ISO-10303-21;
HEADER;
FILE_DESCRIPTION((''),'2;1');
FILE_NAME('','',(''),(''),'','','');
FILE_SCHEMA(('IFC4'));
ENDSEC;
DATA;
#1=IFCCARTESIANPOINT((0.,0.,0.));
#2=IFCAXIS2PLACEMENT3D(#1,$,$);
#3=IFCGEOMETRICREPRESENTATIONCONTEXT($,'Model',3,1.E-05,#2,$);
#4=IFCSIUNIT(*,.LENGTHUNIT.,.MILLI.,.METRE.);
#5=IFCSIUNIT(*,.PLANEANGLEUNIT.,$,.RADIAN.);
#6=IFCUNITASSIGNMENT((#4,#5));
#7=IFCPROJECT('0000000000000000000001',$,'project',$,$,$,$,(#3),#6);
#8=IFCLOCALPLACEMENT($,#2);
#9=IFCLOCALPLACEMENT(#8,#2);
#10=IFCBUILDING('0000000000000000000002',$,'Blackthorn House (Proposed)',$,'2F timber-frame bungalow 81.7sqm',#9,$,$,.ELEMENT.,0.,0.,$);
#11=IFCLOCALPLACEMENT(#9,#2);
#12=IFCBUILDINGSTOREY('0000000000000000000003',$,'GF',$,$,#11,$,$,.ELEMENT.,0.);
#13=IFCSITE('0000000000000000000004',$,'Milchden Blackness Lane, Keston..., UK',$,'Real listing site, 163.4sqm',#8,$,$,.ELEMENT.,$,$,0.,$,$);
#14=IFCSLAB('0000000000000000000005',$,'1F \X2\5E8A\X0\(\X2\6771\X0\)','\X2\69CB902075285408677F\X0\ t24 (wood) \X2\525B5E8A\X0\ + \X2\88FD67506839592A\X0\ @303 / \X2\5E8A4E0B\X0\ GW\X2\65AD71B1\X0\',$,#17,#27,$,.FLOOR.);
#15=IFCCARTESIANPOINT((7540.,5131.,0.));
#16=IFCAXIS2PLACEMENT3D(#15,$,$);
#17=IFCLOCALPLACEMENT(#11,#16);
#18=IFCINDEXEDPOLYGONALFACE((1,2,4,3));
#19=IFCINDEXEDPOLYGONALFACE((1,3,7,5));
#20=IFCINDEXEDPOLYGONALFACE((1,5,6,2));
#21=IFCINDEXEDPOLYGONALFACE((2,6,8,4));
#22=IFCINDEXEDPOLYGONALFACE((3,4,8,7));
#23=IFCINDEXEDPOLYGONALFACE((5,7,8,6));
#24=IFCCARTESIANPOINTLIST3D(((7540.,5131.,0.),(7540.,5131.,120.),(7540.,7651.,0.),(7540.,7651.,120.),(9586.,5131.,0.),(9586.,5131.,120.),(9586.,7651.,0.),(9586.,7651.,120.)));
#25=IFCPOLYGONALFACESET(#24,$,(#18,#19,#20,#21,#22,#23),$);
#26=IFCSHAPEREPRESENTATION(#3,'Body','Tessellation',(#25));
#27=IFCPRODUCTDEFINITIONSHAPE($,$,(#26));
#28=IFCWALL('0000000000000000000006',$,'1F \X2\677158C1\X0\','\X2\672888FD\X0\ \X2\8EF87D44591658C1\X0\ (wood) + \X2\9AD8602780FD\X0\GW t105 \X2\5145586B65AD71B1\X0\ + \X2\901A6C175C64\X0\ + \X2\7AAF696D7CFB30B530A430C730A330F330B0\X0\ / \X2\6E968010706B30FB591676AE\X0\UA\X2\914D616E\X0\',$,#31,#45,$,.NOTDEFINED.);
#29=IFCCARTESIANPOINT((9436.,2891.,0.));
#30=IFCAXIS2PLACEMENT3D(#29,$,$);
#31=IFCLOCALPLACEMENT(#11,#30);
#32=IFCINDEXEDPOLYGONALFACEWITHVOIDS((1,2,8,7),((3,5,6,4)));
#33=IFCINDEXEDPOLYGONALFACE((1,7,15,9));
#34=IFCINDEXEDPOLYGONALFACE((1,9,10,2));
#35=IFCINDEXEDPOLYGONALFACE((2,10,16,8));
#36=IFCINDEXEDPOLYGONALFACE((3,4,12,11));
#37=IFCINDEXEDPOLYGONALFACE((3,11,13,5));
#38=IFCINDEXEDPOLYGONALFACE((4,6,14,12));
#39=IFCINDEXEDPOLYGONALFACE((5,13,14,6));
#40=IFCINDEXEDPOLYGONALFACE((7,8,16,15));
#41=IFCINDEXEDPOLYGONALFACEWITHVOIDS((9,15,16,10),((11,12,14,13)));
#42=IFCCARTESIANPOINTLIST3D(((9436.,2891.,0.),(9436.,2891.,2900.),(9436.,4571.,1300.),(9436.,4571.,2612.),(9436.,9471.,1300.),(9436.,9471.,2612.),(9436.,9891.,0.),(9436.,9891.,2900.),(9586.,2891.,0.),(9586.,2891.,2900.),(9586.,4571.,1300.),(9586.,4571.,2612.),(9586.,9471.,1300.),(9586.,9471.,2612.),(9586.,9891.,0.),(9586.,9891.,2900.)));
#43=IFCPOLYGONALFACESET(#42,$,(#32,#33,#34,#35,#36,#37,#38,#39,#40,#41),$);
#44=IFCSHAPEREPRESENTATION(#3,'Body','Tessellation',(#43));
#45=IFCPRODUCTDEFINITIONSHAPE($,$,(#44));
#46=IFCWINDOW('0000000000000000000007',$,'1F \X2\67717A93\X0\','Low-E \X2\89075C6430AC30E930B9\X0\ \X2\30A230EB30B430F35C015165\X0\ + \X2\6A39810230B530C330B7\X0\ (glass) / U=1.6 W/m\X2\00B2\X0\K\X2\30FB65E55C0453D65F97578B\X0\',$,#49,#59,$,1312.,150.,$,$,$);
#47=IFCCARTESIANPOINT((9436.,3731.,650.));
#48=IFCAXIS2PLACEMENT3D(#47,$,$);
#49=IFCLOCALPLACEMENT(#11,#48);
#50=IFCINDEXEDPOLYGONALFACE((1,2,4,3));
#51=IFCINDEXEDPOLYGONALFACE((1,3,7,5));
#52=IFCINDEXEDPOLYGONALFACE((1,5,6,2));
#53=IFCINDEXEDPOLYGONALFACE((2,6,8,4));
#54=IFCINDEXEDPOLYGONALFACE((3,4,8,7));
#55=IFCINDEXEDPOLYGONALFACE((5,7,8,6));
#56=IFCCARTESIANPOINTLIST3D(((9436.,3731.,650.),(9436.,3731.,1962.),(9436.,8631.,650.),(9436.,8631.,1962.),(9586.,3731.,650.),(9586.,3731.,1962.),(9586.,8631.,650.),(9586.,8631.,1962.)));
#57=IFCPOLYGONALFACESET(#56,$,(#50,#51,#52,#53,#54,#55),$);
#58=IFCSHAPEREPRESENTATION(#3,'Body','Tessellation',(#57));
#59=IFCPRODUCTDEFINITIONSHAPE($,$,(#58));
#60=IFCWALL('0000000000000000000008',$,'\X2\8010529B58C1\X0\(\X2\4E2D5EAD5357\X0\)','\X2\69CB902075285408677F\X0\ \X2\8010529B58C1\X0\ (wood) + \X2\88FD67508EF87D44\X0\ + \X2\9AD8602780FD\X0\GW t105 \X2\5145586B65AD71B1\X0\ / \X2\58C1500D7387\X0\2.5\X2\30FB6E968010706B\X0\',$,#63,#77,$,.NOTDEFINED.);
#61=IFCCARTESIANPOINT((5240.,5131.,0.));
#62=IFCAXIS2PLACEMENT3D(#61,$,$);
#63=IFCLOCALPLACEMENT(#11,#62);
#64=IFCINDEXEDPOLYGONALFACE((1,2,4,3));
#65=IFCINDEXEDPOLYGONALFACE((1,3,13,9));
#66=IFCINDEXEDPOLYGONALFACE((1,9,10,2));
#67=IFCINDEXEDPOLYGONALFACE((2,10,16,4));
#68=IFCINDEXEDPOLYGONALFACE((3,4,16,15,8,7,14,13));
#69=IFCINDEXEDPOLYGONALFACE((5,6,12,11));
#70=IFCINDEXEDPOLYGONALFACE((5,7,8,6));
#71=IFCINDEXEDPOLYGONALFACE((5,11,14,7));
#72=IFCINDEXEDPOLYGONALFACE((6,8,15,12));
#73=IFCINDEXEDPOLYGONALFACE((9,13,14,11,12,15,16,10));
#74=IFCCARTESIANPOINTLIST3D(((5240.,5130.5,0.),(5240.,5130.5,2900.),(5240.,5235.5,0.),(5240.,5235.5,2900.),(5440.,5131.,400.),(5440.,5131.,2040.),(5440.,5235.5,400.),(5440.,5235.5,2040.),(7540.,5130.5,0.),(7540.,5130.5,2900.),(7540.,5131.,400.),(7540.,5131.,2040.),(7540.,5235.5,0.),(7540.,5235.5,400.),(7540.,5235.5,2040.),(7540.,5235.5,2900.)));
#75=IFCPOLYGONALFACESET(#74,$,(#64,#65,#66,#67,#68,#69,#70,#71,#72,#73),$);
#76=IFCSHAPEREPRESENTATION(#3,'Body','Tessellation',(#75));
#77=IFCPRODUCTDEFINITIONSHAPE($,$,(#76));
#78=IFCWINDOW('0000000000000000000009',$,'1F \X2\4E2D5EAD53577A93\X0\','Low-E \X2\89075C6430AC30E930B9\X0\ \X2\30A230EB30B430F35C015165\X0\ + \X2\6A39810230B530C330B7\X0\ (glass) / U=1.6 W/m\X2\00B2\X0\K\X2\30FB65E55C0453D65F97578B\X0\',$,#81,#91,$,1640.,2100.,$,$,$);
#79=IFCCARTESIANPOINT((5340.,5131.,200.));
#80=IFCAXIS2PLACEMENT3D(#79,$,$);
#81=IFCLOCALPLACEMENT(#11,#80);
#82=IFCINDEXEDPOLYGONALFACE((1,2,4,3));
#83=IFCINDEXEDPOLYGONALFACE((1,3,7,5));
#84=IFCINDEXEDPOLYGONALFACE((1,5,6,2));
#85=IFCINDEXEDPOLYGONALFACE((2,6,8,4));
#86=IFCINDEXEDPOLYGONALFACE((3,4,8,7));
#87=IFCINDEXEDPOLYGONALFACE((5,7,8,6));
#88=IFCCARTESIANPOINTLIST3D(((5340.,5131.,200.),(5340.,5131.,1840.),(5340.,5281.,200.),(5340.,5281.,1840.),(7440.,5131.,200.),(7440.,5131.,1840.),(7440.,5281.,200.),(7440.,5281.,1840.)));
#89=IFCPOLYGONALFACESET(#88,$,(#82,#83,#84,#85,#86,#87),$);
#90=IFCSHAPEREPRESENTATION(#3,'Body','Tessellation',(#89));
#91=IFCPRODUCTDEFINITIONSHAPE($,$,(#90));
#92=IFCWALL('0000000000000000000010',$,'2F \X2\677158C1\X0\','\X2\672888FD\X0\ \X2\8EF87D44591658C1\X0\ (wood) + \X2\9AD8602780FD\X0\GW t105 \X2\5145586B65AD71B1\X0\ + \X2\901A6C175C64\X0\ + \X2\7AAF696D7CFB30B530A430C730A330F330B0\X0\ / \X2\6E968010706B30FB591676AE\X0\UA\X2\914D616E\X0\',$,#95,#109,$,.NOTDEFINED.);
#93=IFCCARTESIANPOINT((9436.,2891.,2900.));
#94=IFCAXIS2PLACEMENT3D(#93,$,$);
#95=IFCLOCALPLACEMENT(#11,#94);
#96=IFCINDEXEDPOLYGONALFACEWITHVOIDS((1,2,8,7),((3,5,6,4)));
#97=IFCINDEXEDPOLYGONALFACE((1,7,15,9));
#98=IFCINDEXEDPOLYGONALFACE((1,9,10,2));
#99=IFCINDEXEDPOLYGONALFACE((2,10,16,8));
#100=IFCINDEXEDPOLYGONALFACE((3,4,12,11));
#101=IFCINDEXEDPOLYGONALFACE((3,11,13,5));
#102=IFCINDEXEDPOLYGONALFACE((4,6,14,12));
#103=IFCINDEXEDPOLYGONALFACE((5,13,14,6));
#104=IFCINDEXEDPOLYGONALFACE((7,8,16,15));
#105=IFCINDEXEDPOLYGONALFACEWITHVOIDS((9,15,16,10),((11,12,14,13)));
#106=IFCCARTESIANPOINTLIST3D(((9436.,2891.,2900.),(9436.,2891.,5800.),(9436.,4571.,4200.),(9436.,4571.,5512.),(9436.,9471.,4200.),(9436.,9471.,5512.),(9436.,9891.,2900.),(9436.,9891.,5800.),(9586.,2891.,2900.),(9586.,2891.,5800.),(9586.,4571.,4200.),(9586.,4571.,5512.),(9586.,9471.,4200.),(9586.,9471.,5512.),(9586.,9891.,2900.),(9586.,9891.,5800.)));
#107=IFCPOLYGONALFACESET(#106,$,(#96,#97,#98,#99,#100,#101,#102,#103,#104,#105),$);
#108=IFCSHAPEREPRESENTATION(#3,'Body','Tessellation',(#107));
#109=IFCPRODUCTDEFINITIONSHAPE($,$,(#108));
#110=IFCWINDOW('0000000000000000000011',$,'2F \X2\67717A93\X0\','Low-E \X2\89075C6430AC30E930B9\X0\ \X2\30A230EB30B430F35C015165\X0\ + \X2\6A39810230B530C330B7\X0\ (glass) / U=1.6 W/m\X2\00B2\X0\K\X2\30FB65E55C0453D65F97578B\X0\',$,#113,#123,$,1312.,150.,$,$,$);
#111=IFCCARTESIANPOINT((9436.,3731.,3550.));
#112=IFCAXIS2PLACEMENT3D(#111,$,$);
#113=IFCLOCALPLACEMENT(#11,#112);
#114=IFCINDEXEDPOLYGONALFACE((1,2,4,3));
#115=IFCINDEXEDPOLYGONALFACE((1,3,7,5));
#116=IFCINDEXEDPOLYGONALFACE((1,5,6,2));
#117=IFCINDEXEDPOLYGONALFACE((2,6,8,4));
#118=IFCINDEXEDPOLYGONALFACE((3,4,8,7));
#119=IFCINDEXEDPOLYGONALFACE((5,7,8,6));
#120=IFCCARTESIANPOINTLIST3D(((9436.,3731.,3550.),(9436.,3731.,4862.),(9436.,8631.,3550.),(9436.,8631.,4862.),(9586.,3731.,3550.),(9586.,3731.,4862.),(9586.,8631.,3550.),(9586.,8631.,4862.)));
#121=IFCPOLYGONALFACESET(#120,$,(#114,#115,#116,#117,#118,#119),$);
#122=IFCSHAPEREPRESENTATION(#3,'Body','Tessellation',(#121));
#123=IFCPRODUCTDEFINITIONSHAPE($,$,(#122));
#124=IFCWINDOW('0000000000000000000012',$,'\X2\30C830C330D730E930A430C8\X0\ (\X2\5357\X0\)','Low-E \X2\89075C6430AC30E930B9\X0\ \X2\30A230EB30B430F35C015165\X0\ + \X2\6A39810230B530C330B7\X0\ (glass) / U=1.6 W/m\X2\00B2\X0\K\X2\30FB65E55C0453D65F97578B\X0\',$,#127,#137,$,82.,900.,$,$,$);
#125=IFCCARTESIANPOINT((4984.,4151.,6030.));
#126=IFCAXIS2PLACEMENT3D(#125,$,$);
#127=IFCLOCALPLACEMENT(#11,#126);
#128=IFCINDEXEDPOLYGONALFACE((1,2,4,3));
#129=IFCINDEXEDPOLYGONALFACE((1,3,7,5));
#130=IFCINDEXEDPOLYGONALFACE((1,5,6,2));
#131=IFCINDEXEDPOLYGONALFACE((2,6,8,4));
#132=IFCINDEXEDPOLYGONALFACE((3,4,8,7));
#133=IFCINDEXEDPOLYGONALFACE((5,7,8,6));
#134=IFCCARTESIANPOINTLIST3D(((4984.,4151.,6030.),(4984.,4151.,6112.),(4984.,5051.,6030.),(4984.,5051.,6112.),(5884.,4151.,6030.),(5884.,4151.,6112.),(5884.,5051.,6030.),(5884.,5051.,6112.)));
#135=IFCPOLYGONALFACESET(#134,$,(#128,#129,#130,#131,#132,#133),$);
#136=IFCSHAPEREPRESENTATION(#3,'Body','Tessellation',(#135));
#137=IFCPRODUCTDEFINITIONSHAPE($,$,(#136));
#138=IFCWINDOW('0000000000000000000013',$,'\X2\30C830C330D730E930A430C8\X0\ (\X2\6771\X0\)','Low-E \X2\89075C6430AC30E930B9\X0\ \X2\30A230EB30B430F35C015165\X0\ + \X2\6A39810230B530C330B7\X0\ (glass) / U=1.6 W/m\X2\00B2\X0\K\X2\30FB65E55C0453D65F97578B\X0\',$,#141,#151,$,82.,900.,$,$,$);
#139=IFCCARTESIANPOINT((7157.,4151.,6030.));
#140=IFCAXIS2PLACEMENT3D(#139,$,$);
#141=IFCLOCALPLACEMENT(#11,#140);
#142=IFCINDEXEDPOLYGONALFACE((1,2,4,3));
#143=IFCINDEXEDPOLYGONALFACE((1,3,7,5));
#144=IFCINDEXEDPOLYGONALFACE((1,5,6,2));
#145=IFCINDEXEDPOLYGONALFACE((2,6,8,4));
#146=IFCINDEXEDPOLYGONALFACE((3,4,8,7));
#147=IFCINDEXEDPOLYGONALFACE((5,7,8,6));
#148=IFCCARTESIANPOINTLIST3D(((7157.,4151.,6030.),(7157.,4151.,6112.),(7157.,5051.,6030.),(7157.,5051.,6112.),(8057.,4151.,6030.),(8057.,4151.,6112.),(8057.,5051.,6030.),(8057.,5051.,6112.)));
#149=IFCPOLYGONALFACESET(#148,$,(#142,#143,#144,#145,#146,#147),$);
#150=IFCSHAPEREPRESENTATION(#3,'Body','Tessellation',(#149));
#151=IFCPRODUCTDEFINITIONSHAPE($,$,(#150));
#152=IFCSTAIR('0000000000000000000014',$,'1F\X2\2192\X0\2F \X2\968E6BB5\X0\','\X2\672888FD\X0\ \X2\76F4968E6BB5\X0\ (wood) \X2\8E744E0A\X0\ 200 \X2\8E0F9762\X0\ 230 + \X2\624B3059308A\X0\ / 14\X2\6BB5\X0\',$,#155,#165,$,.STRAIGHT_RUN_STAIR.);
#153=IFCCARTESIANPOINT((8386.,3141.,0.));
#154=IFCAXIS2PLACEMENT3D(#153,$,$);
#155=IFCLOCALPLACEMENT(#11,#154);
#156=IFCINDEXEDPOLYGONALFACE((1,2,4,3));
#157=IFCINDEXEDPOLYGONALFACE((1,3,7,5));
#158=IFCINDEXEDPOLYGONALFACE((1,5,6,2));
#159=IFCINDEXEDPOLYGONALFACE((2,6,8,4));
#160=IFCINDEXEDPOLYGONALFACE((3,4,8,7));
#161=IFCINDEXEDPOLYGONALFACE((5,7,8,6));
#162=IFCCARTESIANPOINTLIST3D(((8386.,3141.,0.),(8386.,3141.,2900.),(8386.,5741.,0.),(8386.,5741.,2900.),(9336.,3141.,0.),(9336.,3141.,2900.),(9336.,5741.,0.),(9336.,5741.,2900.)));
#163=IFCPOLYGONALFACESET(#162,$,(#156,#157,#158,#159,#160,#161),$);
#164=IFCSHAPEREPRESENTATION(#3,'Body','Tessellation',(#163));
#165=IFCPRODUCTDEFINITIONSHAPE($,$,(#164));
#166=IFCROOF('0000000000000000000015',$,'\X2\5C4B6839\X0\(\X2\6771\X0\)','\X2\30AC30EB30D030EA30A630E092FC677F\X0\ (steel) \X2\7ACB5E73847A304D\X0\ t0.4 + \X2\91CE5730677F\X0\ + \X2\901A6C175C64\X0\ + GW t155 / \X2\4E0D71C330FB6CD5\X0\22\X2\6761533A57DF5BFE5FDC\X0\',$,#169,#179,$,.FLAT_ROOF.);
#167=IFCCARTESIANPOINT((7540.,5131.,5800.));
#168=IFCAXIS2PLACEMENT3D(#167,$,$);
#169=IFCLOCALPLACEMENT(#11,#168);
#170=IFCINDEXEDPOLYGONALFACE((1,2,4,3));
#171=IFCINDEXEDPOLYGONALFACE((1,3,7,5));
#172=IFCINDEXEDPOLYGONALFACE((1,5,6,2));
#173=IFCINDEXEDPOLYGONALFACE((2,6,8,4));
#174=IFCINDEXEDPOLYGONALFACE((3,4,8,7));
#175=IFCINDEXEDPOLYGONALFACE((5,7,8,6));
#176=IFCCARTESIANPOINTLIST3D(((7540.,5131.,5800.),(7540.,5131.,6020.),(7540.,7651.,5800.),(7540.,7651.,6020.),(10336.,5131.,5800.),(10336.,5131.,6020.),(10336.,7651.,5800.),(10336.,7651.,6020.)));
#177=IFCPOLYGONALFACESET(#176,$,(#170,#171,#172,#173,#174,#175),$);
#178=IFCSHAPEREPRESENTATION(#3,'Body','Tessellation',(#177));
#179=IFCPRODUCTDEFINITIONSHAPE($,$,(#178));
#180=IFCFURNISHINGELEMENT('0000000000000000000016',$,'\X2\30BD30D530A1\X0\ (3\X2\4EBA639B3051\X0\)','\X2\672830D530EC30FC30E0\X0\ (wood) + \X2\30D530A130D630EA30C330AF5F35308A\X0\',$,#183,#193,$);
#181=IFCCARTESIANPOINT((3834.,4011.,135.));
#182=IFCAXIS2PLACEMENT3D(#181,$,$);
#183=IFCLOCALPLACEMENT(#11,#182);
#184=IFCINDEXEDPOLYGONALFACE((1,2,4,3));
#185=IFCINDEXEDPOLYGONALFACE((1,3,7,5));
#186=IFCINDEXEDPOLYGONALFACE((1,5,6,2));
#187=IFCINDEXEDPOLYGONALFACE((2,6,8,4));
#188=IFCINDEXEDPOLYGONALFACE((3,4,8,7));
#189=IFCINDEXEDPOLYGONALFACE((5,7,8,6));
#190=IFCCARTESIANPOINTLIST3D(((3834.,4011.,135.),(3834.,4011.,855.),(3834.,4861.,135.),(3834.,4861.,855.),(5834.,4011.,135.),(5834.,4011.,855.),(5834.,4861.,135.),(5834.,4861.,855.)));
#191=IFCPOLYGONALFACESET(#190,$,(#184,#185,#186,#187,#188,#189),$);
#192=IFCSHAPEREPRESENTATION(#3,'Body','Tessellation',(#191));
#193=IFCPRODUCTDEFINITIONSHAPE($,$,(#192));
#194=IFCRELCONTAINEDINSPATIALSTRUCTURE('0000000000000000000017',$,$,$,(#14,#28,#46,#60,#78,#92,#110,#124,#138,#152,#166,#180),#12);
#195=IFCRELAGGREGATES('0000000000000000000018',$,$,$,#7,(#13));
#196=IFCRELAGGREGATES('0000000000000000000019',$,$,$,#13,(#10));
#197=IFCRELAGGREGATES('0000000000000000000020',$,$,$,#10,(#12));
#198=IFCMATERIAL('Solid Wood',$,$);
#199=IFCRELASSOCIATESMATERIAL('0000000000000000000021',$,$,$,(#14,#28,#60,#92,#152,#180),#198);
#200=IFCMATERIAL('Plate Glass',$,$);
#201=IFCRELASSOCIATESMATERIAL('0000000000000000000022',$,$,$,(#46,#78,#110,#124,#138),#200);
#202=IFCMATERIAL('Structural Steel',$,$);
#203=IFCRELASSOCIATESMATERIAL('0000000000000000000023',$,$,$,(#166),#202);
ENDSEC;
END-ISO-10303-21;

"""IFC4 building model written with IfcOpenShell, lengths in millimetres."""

from ifc_helpers import new_model, si_unit, frame, frame_2d, origin, place, context, project, spatial, rectangle, extrude, material, element, fill, save


model = new_model("IFC4")

# Units and contexts
model_context = context("Model", 3, precision=1e-05, world=origin())
ifc_project = project(units=[si_unit("LENGTHUNIT", "METRE", prefix="MILLI"), si_unit("PLANEANGLEUNIT", "RADIAN")], contexts=[model_context])

# Site, building, storey
site_placement = place(None, origin())
site = spatial("IfcSite", under=ifc_project, at=site_placement, Name="Milchden Blackness Lane, Keston..., UK", ObjectType="Real listing site, 163.4sqm", CompositionType="ELEMENT", RefElevation=0.0)
building_placement = place(site_placement, origin())
building = spatial("IfcBuilding", under=site, at=building_placement, Name="Blackthorn House (Proposed)", ObjectType="2F timber-frame bungalow 81.7sqm", CompositionType="ELEMENT", ElevationOfRefHeight=0.0, ElevationOfTerrain=0.0)
storey_placement = place(building_placement, origin())
storey = spatial("IfcBuildingStorey", under=building, at=storey_placement, Name="GF", CompositionType="ELEMENT", Elevation=0.0)

# Slab
ifc_material_1 = material(Name="Solid Wood")
slab_placement = place(storey_placement, frame((7540.0, 5131.0, 0.0)))
element("IfcSlab", 1, at=slab_placement, inside=storey, material=ifc_material_1, Name="1F 床(東)", Description="構造用合板 t24 (wood) 剛床 + 製材根太 @303 / 床下 GW断熱", PredefinedType="FLOOR", context=model_context, shape_type="SweptSolid", body=[
    extrude(rectangle(XDim=2046.0, YDim=2520.0, at=frame_2d((1023.0, 1260.0))), frame((7540.0, 5131.0, 0.0)), (0.0, 0.0, 1.0), 120.0),
])

# Walls, openings, windows
wall_1_placement = place(storey_placement, frame((9436.0, 2891.0, 0.0)))
wall_1 = element("IfcWall", 2, at=wall_1_placement, inside=storey, material=ifc_material_1, Name="1F 東壁", Description="木製 軸組外壁 (wood) + 高性能GW t105 充填断熱 + 通気層 + 窯業系サイディング / 準耐火・外皮UA配慮", PredefinedType="NOTDEFINED", context=model_context, shape_type="SweptSolid", body=[
    extrude(rectangle(XDim=150.0, YDim=7000.0, at=frame_2d((75.0, 3500.0))), frame((9436.0, 2891.0, 0.0)), (0.0, 0.0, 1.0), 2900.0),
])
opening_1_placement = place(storey_placement, frame((9436.0, 3731.0, 650.0)))
opening_1 = element("IfcOpeningElement", 3, at=opening_1_placement, cuts=wall_1, PredefinedType="NOTDEFINED", context=model_context, shape_type="SweptSolid", body=[
    extrude(rectangle(XDim=150.0, YDim=4900.0, at=frame_2d((75.0, 2450.0))), frame((9436.0, 3731.0, 650.0)), (0.0, 0.0, 1.0), 1312.0),
])
ifc_material_2 = material(Name="Plate Glass")
window_1_placement = place(storey_placement, frame((9436.0, 3731.0, 650.0)))
window_1 = element("IfcWindow", 4, at=window_1_placement, inside=storey, material=ifc_material_2, Name="1F 東窓", Description="Low-E 複層ガラス アルゴン封入 + 樹脂サッシ (glass) / U=1.6 W/m²K・日射取得型", OverallHeight=1312.0, OverallWidth=150.0, context=model_context, shape_type="SweptSolid", body=[
    extrude(rectangle(XDim=150.0, YDim=4900.0, at=frame_2d((75.0, 2450.0))), frame((9436.0, 3731.0, 650.0)), (0.0, 0.0, 1.0), 1312.0),
])
fill(opening_1, window_1)
wall_2_placement = place(storey_placement, frame((5240.0, 5131.0, 0.0)))
wall_2 = element("IfcWall", 5, at=wall_2_placement, inside=storey, material=ifc_material_1, Name="耐力壁(中庭南)", Description="構造用合板 耐力壁 (wood) + 製材軸組 + 高性能GW t105 充填断熱 / 壁倍率2.5・準耐火", PredefinedType="NOTDEFINED", context=model_context, shape_type="SweptSolid", body=[
    extrude(rectangle(XDim=2300.0, YDim=105.0, at=frame_2d((1150.0, 52.0))), frame((5240.0, 5131.0, 0.0)), (0.0, 0.0, 1.0), 2900.0),
])
opening_2_placement = place(storey_placement, frame((5340.0, 5131.0, 200.0)))
opening_2 = element("IfcOpeningElement", 6, at=opening_2_placement, cuts=wall_2, PredefinedType="NOTDEFINED", context=model_context, shape_type="SweptSolid", body=[
    extrude(rectangle(XDim=2100.0, YDim=150.0, at=frame_2d((1050.0, 75.0))), frame((5340.0, 5131.0, 200.0)), (0.0, 0.0, 1.0), 1640.0),
])
window_2_placement = place(storey_placement, frame((5340.0, 5131.0, 200.0)))
window_2 = element("IfcWindow", 7, at=window_2_placement, inside=storey, material=ifc_material_2, Name="1F 中庭南窓", Description="Low-E 複層ガラス アルゴン封入 + 樹脂サッシ (glass) / U=1.6 W/m²K・日射取得型", OverallHeight=1640.0, OverallWidth=2100.0, context=model_context, shape_type="SweptSolid", body=[
    extrude(rectangle(XDim=2100.0, YDim=150.0, at=frame_2d((1050.0, 75.0))), frame((5340.0, 5131.0, 200.0)), (0.0, 0.0, 1.0), 1640.0),
])
fill(opening_2, window_2)

# Wall, opening, window
wall_3_placement = place(storey_placement, frame((9436.0, 2891.0, 2900.0)))
wall_3 = element("IfcWall", 8, at=wall_3_placement, inside=storey, material=ifc_material_1, Name="2F 東壁", Description="木製 軸組外壁 (wood) + 高性能GW t105 充填断熱 + 通気層 + 窯業系サイディング / 準耐火・外皮UA配慮", PredefinedType="NOTDEFINED", context=model_context, shape_type="SweptSolid", body=[
    extrude(rectangle(XDim=150.0, YDim=7000.0, at=frame_2d((75.0, 3500.0))), frame((9436.0, 2891.0, 2900.0)), (0.0, 0.0, 1.0), 2900.0),
])
opening_3_placement = place(storey_placement, frame((9436.0, 3731.0, 3550.0)))
opening_3 = element("IfcOpeningElement", 9, at=opening_3_placement, cuts=wall_3, PredefinedType="NOTDEFINED", context=model_context, shape_type="SweptSolid", body=[
    extrude(rectangle(XDim=150.0, YDim=4900.0, at=frame_2d((75.0, 2450.0))), frame((9436.0, 3731.0, 3550.0)), (0.0, 0.0, 1.0), 1312.0),
])
window_3_placement = place(storey_placement, frame((9436.0, 3731.0, 3550.0)))
window_3 = element("IfcWindow", 10, at=window_3_placement, inside=storey, material=ifc_material_2, Name="2F 東窓", Description="Low-E 複層ガラス アルゴン封入 + 樹脂サッシ (glass) / U=1.6 W/m²K・日射取得型", OverallHeight=1312.0, OverallWidth=150.0, context=model_context, shape_type="SweptSolid", body=[
    extrude(rectangle(XDim=150.0, YDim=4900.0, at=frame_2d((75.0, 2450.0))), frame((9436.0, 3731.0, 3550.0)), (0.0, 0.0, 1.0), 1312.0),
])
fill(opening_3, window_3)

# Windows
window_4_placement = place(storey_placement, frame((4984.0, 4151.0, 6030.0)))
element("IfcWindow", 11, at=window_4_placement, inside=storey, material=ifc_material_2, Name="トップライト (南)", Description="Low-E 複層ガラス アルゴン封入 + 樹脂サッシ (glass) / U=1.6 W/m²K・日射取得型", OverallHeight=82.0, OverallWidth=900.0, context=model_context, shape_type="SweptSolid", body=[
    extrude(rectangle(XDim=900.0, YDim=900.0, at=frame_2d((450.0, 450.0))), frame((4984.0, 4151.0, 6030.0)), (0.0, 0.0, 1.0), 82.0),
])
window_5_placement = place(storey_placement, frame((7157.0, 4151.0, 6030.0)))
element("IfcWindow", 12, at=window_5_placement, inside=storey, material=ifc_material_2, Name="トップライト (東)", Description="Low-E 複層ガラス アルゴン封入 + 樹脂サッシ (glass) / U=1.6 W/m²K・日射取得型", OverallHeight=82.0, OverallWidth=900.0, context=model_context, shape_type="SweptSolid", body=[
    extrude(rectangle(XDim=900.0, YDim=900.0, at=frame_2d((450.0, 450.0))), frame((7157.0, 4151.0, 6030.0)), (0.0, 0.0, 1.0), 82.0),
])

# Stair
stair_placement = place(storey_placement, frame((8386.0, 3141.0, 0.0)))
element("IfcStair", 13, at=stair_placement, inside=storey, material=ifc_material_1, Name="1F→2F 階段", Description="木製 直階段 (wood) 蹴上 200 踏面 230 + 手すり / 14段", PredefinedType="STRAIGHT_RUN_STAIR", context=model_context, shape_type="SweptSolid", body=[
    extrude(rectangle(XDim=950.0, YDim=2600.0, at=frame_2d((475.0, 1300.0))), frame((8386.0, 3141.0, 0.0)), (0.0, 0.0, 1.0), 2900.0),
])

# Roof
ifc_material_3 = material(Name="Structural Steel")
roof_placement = place(storey_placement, frame((7540.0, 5131.0, 5800.0)))
element("IfcRoof", 14, at=roof_placement, inside=storey, material=ifc_material_3, Name="屋根(東)", Description="ガルバリウム鋼板 (steel) 立平葺き t0.4 + 野地板 + 通気層 + GW t155 / 不燃・法22条区域対応", PredefinedType="FLAT_ROOF", context=model_context, shape_type="SweptSolid", body=[
    extrude(rectangle(XDim=2796.0, YDim=2520.0, at=frame_2d((1398.0, 1260.0))), frame((7540.0, 5131.0, 5800.0)), (0.0, 0.0, 1.0), 220.0),
])

# Furnishing element
furnishing_1_placement = place(storey_placement, frame((3834.0, 4011.0, 135.0)))
element("IfcFurnishingElement", 15, at=furnishing_1_placement, inside=storey, material=ifc_material_1, Name="ソファ (3人掛け)", Description="木フレーム (wood) + ファブリック張り", context=model_context, shape_type="SweptSolid", body=[
    extrude(rectangle(XDim=2000.0, YDim=850.0, at=frame_2d((1000.0, 425.0))), frame((3834.0, 4011.0, 135.0)), (0.0, 0.0, 1.0), 720.0),
])

save(model, "model.ifc")
